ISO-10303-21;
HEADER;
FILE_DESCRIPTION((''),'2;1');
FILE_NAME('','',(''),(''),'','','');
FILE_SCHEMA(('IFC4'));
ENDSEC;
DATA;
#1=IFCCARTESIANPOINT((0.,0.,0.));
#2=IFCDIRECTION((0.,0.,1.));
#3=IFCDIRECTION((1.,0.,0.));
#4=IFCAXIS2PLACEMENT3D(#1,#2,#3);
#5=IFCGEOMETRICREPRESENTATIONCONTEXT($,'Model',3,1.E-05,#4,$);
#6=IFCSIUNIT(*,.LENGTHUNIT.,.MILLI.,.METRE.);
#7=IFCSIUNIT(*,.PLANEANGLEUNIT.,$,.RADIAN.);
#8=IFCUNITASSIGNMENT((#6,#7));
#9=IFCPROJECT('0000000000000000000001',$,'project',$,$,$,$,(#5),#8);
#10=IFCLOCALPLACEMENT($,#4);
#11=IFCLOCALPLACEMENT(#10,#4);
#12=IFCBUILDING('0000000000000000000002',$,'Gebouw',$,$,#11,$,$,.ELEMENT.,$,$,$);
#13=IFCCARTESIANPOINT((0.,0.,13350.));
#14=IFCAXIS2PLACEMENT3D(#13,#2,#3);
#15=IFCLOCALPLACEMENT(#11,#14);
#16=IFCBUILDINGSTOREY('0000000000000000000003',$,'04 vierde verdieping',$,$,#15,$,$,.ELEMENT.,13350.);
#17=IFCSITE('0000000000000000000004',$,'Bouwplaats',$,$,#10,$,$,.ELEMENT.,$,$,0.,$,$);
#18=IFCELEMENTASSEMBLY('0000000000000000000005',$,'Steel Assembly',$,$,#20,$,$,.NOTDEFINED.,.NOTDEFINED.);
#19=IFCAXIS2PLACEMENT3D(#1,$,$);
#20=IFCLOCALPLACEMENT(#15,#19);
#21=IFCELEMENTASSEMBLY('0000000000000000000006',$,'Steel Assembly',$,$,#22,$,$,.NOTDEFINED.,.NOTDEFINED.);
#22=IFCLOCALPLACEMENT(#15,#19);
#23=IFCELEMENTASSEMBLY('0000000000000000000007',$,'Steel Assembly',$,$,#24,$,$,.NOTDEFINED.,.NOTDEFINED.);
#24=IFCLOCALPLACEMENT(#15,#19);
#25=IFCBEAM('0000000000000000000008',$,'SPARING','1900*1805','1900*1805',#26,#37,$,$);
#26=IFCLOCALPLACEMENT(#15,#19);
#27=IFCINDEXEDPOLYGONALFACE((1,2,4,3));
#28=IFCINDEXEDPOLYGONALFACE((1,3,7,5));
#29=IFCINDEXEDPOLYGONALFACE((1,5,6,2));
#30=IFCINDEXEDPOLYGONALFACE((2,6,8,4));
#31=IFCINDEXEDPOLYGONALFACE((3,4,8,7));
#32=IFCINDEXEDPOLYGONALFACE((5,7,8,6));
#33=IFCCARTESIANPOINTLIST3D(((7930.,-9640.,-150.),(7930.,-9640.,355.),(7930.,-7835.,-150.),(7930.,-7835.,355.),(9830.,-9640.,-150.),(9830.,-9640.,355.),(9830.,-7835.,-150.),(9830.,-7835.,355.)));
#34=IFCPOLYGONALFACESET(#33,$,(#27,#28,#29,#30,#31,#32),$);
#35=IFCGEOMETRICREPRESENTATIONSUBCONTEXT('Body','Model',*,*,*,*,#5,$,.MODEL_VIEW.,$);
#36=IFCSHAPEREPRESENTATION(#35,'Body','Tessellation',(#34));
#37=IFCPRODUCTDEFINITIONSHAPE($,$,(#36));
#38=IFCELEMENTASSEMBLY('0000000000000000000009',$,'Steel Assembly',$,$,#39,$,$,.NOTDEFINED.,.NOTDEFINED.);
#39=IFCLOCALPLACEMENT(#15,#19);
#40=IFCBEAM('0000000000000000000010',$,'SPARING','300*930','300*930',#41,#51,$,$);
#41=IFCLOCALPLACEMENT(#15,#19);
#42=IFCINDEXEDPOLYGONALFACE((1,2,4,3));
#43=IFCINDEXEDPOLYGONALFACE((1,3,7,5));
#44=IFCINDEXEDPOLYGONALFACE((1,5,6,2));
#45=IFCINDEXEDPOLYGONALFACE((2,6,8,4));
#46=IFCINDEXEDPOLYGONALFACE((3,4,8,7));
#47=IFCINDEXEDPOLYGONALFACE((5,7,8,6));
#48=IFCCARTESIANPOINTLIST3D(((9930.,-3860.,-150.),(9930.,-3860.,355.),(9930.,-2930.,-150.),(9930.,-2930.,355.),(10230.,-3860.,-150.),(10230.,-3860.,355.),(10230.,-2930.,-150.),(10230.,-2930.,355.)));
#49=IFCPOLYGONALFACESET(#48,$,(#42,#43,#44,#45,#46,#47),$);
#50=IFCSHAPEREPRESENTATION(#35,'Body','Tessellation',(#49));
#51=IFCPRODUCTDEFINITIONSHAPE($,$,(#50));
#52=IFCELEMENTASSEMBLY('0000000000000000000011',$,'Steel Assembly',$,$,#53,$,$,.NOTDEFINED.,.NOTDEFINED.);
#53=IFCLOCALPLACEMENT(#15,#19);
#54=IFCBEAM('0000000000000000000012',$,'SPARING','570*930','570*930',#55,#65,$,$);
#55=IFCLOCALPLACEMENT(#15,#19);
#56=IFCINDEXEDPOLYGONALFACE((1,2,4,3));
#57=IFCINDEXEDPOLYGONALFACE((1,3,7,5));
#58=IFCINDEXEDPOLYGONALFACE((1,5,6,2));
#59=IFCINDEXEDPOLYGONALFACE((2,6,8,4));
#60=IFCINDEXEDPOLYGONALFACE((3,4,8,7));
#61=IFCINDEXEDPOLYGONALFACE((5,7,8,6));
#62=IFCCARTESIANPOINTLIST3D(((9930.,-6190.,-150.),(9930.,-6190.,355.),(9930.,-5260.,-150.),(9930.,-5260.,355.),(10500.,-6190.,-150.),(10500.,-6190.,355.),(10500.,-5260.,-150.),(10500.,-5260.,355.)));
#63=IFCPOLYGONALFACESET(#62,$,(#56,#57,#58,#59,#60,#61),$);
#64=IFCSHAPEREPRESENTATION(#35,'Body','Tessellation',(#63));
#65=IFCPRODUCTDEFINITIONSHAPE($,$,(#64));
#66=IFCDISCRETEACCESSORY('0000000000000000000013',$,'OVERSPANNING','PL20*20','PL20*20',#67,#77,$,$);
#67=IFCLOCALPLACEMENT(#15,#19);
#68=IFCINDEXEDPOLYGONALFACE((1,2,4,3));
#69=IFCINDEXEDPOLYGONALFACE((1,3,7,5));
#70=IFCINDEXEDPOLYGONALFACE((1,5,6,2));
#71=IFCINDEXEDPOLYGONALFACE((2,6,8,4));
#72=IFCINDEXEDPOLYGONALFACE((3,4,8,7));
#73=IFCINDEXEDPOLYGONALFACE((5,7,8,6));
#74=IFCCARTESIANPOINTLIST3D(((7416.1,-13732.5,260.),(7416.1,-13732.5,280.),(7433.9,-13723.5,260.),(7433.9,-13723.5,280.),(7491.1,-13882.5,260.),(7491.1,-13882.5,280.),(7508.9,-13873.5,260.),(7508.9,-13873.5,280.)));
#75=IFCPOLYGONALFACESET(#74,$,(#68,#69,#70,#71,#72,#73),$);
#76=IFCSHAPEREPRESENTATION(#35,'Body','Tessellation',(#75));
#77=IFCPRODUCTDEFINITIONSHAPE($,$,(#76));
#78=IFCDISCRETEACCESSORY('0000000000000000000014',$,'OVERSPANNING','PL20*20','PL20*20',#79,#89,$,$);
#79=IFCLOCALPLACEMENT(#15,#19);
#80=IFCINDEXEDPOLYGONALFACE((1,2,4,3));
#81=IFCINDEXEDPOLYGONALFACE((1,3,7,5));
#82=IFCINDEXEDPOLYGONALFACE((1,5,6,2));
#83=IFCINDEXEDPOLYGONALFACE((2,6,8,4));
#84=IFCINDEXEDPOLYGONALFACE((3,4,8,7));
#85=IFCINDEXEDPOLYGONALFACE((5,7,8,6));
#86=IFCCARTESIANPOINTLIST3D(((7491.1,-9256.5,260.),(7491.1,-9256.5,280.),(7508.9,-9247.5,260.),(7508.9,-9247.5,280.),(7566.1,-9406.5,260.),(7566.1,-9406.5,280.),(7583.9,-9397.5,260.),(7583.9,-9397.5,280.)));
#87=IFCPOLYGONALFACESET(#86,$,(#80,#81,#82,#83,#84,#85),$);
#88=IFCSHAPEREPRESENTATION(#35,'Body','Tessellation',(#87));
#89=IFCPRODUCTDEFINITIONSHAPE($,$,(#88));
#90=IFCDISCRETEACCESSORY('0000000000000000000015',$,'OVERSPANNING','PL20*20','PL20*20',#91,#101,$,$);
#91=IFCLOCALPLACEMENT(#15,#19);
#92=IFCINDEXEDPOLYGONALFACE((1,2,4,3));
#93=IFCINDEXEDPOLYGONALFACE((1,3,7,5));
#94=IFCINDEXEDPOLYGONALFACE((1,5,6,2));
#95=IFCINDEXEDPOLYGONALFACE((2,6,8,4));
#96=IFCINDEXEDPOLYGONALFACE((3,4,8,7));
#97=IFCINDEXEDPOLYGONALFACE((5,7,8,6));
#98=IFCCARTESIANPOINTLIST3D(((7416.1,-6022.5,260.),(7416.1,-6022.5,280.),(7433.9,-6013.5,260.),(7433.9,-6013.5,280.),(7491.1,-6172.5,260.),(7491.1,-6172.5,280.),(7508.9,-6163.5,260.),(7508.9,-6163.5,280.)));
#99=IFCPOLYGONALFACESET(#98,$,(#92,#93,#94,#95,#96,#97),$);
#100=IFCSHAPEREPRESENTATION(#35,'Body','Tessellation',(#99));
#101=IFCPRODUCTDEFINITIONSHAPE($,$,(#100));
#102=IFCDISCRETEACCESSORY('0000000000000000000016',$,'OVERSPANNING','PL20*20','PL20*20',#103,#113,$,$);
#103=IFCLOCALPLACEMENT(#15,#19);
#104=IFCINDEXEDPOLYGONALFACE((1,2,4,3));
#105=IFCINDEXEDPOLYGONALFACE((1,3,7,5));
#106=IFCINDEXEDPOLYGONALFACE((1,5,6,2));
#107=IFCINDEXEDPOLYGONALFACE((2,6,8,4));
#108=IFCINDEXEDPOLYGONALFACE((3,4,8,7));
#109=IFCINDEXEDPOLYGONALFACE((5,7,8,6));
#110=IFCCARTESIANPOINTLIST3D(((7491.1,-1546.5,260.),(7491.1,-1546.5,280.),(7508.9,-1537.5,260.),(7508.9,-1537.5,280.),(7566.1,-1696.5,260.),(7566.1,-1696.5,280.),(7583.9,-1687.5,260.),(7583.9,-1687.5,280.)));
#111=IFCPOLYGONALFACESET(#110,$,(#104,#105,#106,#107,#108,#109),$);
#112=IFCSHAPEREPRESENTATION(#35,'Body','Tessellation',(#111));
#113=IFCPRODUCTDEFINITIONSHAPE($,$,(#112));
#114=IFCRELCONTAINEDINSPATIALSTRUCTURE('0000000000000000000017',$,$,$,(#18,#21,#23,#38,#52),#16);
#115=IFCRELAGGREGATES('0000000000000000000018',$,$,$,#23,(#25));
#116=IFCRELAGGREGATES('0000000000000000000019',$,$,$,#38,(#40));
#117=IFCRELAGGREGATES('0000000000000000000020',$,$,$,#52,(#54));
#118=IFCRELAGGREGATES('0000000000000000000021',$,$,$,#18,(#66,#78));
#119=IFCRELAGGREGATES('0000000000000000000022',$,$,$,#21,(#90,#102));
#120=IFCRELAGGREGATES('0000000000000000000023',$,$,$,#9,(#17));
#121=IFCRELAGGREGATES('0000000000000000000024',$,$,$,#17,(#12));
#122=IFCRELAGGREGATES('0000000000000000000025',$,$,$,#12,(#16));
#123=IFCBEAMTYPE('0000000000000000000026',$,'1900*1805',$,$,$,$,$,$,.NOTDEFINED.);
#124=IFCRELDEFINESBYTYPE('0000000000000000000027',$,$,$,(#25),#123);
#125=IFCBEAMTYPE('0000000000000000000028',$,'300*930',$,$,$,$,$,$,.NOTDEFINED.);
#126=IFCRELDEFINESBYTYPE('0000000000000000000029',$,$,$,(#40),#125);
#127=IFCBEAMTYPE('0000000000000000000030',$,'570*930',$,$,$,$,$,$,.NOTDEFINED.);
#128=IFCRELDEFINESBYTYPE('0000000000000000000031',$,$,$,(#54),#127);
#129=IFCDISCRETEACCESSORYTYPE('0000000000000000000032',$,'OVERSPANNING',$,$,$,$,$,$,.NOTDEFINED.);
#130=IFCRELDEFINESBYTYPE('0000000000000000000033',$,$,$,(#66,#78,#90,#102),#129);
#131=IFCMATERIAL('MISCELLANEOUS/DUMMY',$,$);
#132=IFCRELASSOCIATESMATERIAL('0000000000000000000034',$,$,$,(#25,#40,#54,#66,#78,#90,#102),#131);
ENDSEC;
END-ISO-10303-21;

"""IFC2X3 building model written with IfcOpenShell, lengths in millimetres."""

from ifc_helpers import new_model, si_unit, frame, origin_with_axes, origin_2d_with_axis, place, context, subcontext, project, spatial, rectangle, extrude, material, type_object, element, aggregate, save


model = new_model("IFC2X3")

# Units and contexts
model_context = context("Model", 3, precision=1e-05, world=origin_with_axes())
body_context = subcontext(model_context, "Body", "Model", "MODEL_VIEW")
ifc_project = project(units=[si_unit("LENGTHUNIT", "METRE", prefix="MILLI"), si_unit("PLANEANGLEUNIT", "RADIAN")], contexts=[model_context])

# Site, building, storey
site_placement = place(None, origin_with_axes())
site = spatial("IfcSite", under=ifc_project, at=site_placement, Name="Bouwplaats", CompositionType="ELEMENT", RefElevation=0.0)
building_placement = place(site_placement, origin_with_axes())
building = spatial("IfcBuilding", under=site, at=building_placement, Name="Gebouw", CompositionType="ELEMENT")
storey_placement = place(building_placement, frame((0.0, 0.0, 13350.0), z_axis=(0.0, 0.0, 1.0), x_axis=(1.0, 0.0, 0.0)))
storey = spatial("IfcBuildingStorey", under=building, at=storey_placement, Name="04 vierde verdieping", CompositionType="ELEMENT", Elevation=13350.0)

# Element assemblies, beams
ifc_material = material(Name="MISCELLANEOUS/DUMMY")
assembly_1_placement = place(storey_placement, origin_with_axes())
assembly_1 = element("IfcElementAssembly", 1, at=assembly_1_placement, inside=storey, Name="Steel Assembly", AssemblyPlace="NOTDEFINED", PredefinedType="NOTDEFINED")
assembly_2_placement = place(storey_placement, origin_with_axes())
assembly_2 = element("IfcElementAssembly", 2, at=assembly_2_placement, inside=storey, Name="Steel Assembly", AssemblyPlace="NOTDEFINED", PredefinedType="NOTDEFINED")
beam_type_1 = type_object("IfcBeamType", Name="1900*1805", PredefinedType="NOTDEFINED")
assembly_3_placement = place(storey_placement, origin_with_axes())
assembly_3 = element("IfcElementAssembly", 3, at=assembly_3_placement, inside=storey, Name="Steel Assembly", AssemblyPlace="NOTDEFINED", PredefinedType="NOTDEFINED")
beam_1_placement = place(assembly_3_placement, frame((8880.0, -8737.5, 355.0), z_axis=(0.000004, 1.0, 0.0), x_axis=(0.0, 0.0, -1.0)))
beam_1 = element("IfcBeam", 4, at=beam_1_placement, type_object=beam_type_1, material=ifc_material, Name="SPARING", Description="1900*1805", ObjectType="1900*1805", context=body_context, shape_type="SweptSolid", body=[
    extrude(rectangle(XDim=1900.0, YDim=1805.0, at=origin_2d_with_axis()), frame((505.0, 0.0, 0.0), z_axis=(-1.0, 0.0, 0.0), x_axis=(0.0, -1.0, 0.0)), (0.0, 0.0, 1.0), 505.0),
])
aggregate(assembly_3, [beam_1])
assembly_4_placement = place(storey_placement, origin_with_axes())
assembly_4 = element("IfcElementAssembly", 5, at=assembly_4_placement, inside=storey, Name="Steel Assembly", AssemblyPlace="NOTDEFINED", PredefinedType="NOTDEFINED")
beam_type_2 = type_object("IfcBeamType", Name="300*930", PredefinedType="NOTDEFINED")
beam_2_placement = place(assembly_4_placement, frame((10080.0, -3395.0, 355.0), z_axis=(0.000004, 1.0, 0.0), x_axis=(0.0, 0.0, -1.0)))
beam_2 = element("IfcBeam", 6, at=beam_2_placement, type_object=beam_type_2, material=ifc_material, Name="SPARING", Description="300*930", ObjectType="300*930", context=body_context, shape_type="SweptSolid", body=[
    extrude(rectangle(XDim=300.0, YDim=930.0, at=origin_2d_with_axis()), frame((505.0, 0.0, 0.0), z_axis=(-1.0, 0.0, 0.0), x_axis=(0.0, -1.0, 0.0)), (0.0, 0.0, 1.0), 505.0),
])
aggregate(assembly_4, [beam_2])
assembly_5_placement = place(storey_placement, origin_with_axes())
assembly_5 = element("IfcElementAssembly", 7, at=assembly_5_placement, inside=storey, Name="Steel Assembly", AssemblyPlace="NOTDEFINED", PredefinedType="NOTDEFINED")
beam_type_3 = type_object("IfcBeamType", Name="570*930", PredefinedType="NOTDEFINED")
beam_3_placement = place(assembly_5_placement, frame((10215.0, -5725.0, 355.0), z_axis=(0.000004, 1.0, 0.0), x_axis=(0.0, 0.0, -1.0)))
beam_3 = element("IfcBeam", 8, at=beam_3_placement, type_object=beam_type_3, material=ifc_material, Name="SPARING", Description="570*930", ObjectType="570*930", context=body_context, shape_type="SweptSolid", body=[
    extrude(rectangle(XDim=570.0, YDim=930.0, at=origin_2d_with_axis()), frame((505.0, 0.0, 0.0), z_axis=(-1.0, 0.0, 0.0), x_axis=(0.0, -1.0, 0.0)), (0.0, 0.0, 1.0), 505.0),
])
aggregate(assembly_5, [beam_3])

# Discrete accessories
discrete_accessory_type = type_object("IfcDiscreteAccessoryType", Name="OVERSPANNING")
discrete_accessory_1_placement = place(assembly_1_placement, frame((7425.0, -13728.0, 270.0), z_axis=(0.894427, 0.447214, 0.0), x_axis=(0.447214, -0.894427, 0.0)))
discrete_accessory_1 = element("IfcDiscreteAccessory", 9, at=discrete_accessory_1_placement, type_object=discrete_accessory_type, material=ifc_material, Name="OVERSPANNING", Description="PL20*20", ObjectType="PL20*20", context=body_context, shape_type="SweptSolid", body=[
    extrude(rectangle(XDim=20.0, YDim=20.0, at=origin_2d_with_axis()), frame((167.7, 0.0, 0.0), z_axis=(-1.0, 0.0, 0.0), x_axis=(0.0, -1.0, 0.0)), (0.0, 0.0, 1.0), 167.7),
])
discrete_accessory_2_placement = place(assembly_1_placement, frame((7575.0, -9402.0, 270.0), z_axis=(-0.894427, -0.447214, 0.0), x_axis=(-0.447214, 0.894427, 0.0)))
discrete_accessory_2 = element("IfcDiscreteAccessory", 10, at=discrete_accessory_2_placement, type_object=discrete_accessory_type, material=ifc_material, Name="OVERSPANNING", Description="PL20*20", ObjectType="PL20*20", context=body_context, shape_type="SweptSolid", body=[
    extrude(rectangle(XDim=20.0, YDim=20.0, at=origin_2d_with_axis()), frame((167.7, 0.0, 0.0), z_axis=(-1.0, 0.0, 0.0), x_axis=(0.0, -1.0, 0.0)), (0.0, 0.0, 1.0), 167.7),
])
aggregate(assembly_1, [discrete_accessory_1, discrete_accessory_2])
discrete_accessory_3_placement = place(assembly_2_placement, frame((7425.0, -6018.0, 270.0), z_axis=(0.894427, 0.447214, 0.0), x_axis=(0.447214, -0.894427, 0.0)))
discrete_accessory_3 = element("IfcDiscreteAccessory", 11, at=discrete_accessory_3_placement, type_object=discrete_accessory_type, material=ifc_material, Name="OVERSPANNING", Description="PL20*20", ObjectType="PL20*20", context=body_context, shape_type="SweptSolid", body=[
    extrude(rectangle(XDim=20.0, YDim=20.0, at=origin_2d_with_axis()), frame((167.7, 0.0, 0.0), z_axis=(-1.0, 0.0, 0.0), x_axis=(0.0, -1.0, 0.0)), (0.0, 0.0, 1.0), 167.7),
])
discrete_accessory_4_placement = place(assembly_2_placement, frame((7575.0, -1692.0, 270.0), z_axis=(-0.894427, -0.447214, 0.0), x_axis=(-0.447214, 0.894427, 0.0)))
discrete_accessory_4 = element("IfcDiscreteAccessory", 12, at=discrete_accessory_4_placement, type_object=discrete_accessory_type, material=ifc_material, Name="OVERSPANNING", Description="PL20*20", ObjectType="PL20*20", context=body_context, shape_type="SweptSolid", body=[
    extrude(rectangle(XDim=20.0, YDim=20.0, at=origin_2d_with_axis()), frame((167.7, 0.0, 0.0), z_axis=(-1.0, 0.0, 0.0), x_axis=(0.0, -1.0, 0.0)), (0.0, 0.0, 1.0), 167.7),
])
aggregate(assembly_2, [discrete_accessory_3, discrete_accessory_4])

save(model, "model.ifc")
